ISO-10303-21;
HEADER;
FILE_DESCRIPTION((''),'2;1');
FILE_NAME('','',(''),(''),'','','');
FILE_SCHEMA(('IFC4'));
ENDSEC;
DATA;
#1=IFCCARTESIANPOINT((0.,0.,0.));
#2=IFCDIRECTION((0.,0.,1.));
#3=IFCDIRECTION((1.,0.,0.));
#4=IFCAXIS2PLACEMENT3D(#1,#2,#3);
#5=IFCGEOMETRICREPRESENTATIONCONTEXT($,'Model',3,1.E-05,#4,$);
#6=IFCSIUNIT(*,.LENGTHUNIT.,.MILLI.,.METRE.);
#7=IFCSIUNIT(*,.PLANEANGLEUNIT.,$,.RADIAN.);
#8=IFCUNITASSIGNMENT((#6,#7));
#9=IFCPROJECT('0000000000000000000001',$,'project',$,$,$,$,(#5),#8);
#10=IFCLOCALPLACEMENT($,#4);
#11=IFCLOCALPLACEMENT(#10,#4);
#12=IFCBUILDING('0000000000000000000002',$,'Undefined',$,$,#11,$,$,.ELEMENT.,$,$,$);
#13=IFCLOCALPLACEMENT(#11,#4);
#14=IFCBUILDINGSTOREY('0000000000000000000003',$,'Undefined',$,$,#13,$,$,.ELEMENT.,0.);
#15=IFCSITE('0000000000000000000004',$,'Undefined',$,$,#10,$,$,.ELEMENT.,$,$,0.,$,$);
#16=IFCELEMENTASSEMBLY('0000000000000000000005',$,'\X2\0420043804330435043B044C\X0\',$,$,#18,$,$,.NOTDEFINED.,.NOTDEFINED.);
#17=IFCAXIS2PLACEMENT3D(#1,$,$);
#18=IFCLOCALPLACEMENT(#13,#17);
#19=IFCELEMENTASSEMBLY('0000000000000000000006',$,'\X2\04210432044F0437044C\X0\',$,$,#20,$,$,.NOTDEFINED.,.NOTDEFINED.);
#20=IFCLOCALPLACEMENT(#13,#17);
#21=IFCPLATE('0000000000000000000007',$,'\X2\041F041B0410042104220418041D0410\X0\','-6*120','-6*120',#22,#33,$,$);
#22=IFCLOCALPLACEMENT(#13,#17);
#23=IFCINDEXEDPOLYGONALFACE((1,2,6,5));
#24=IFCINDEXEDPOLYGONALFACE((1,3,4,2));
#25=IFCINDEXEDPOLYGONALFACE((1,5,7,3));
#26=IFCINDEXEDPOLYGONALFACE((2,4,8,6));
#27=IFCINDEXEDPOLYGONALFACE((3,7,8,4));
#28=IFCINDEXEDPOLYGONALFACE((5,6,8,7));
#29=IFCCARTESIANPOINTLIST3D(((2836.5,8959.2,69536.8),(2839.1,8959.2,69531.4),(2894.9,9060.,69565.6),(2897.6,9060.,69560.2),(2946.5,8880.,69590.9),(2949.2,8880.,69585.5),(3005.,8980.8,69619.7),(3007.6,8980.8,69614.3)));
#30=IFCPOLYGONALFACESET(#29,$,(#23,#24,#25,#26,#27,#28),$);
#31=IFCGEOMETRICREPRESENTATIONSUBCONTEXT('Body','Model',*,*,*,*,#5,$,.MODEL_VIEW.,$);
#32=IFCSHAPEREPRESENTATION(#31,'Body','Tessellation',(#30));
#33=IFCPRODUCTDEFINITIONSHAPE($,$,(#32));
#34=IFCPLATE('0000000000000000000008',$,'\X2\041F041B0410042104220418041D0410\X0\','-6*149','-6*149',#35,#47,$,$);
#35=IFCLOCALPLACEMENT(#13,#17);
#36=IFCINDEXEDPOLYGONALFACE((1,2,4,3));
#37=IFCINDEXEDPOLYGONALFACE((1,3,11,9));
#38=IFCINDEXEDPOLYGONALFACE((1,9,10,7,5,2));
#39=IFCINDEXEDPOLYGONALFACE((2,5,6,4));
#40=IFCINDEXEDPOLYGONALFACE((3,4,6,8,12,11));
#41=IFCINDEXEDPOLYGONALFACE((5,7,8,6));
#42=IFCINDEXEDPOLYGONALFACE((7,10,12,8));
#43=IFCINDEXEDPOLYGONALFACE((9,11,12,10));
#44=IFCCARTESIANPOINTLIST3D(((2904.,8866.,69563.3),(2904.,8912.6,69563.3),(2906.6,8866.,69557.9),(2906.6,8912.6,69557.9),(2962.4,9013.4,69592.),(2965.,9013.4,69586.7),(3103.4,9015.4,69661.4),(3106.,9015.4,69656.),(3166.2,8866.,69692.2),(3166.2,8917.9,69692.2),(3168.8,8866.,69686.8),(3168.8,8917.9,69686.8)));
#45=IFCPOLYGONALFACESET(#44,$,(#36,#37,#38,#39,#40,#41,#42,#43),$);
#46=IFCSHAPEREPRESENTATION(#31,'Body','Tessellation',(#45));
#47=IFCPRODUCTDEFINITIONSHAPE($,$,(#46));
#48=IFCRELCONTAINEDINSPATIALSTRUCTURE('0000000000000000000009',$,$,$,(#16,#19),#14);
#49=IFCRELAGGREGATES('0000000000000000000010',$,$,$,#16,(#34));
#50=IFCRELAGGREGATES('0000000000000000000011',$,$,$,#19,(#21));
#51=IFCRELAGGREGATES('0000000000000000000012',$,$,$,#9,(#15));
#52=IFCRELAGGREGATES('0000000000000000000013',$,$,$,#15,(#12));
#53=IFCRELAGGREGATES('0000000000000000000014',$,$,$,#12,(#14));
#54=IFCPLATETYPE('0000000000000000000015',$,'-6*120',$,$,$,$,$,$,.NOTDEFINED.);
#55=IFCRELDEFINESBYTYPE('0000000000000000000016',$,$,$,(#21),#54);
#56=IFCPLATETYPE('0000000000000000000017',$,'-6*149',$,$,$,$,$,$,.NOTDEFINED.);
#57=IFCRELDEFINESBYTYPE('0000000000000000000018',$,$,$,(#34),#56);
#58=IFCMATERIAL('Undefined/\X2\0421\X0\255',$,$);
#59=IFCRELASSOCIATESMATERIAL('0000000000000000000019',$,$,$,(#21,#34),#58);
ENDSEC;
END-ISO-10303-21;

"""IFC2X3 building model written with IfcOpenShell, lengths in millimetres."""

from ifc_helpers import new_model, si_unit, frame, origin_with_axes, place, context, subcontext, project, spatial, polyline, outline, extrude, material, type_object, element, aggregate, save


model = new_model("IFC2X3")

# Units and contexts
model_context = context("Model", 3, precision=1e-05, world=origin_with_axes())
body_context = subcontext(model_context, "Body", "Model", "MODEL_VIEW")
ifc_project = project(units=[si_unit("LENGTHUNIT", "METRE", prefix="MILLI"), si_unit("PLANEANGLEUNIT", "RADIAN")], contexts=[model_context])

# Site, building, storey
site_placement = place(None, origin_with_axes())
site = spatial("IfcSite", under=ifc_project, at=site_placement, Name="Undefined", CompositionType="ELEMENT", RefElevation=0.0)
building_placement = place(site_placement, origin_with_axes())
building = spatial("IfcBuilding", under=site, at=building_placement, Name="Undefined", CompositionType="ELEMENT")
storey_placement = place(building_placement, origin_with_axes())
storey = spatial("IfcBuildingStorey", under=building, at=storey_placement, Name="Undefined", CompositionType="ELEMENT", Elevation=0.0)

# Element assembly
assembly_1_placement = place(storey_placement, origin_with_axes())
assembly_1 = element("IfcElementAssembly", 1, at=assembly_1_placement, inside=storey, Name="Ригель", AssemblyPlace="NOTDEFINED", PredefinedType="NOTDEFINED")
ifc_material_1 = material(Name="Undefined/С255")

# Element assembly
assembly_2_placement = place(storey_placement, origin_with_axes())
assembly_2 = element("IfcElementAssembly", 2, at=assembly_2_placement, inside=storey, Name="Связь", AssemblyPlace="NOTDEFINED", PredefinedType="NOTDEFINED")

# Plates
plate_type_1 = type_object("IfcPlateType", Name="-6*120", PredefinedType="NOTDEFINED")
plate_1_placement = place(assembly_2_placement, frame((2947.9, 8880.0, 69588.2), z_axis=(-0.441222, -0.000001, 0.897398), x_axis=(0.48707, 0.839889, 0.239478)))
plate_1 = element("IfcPlate", 3, at=plate_1_placement, type_object=plate_type_1, material=ifc_material_1, Name="ПЛАСТИНА", Description="-6*120", ObjectType="-6*120", context=body_context, shape_type="SweptSolid", body=[
    extrude(outline(polyline([(0.0, 0.0), (120.0, 0.0), (120.0, 146.0), (0.0, 146.0), (0.0, 0.0)])), frame((0.0, 0.0, -3.0), z_axis=(0.0, 0.0, 1.0), x_axis=(1.0, 0.0, 0.0)), (0.0, 0.0, 1.0), 6.0),
])
plate_type_2 = type_object("IfcPlateType", Name="-6*149", PredefinedType="NOTDEFINED")
plate_2_placement = place(assembly_1_placement, frame((2905.3, 8866.0, 69560.6), z_axis=(-0.441224, 0.0, 0.897397), x_axis=(0.897397, 0.000027, 0.441224)))
plate_2 = element("IfcPlate", 4, at=plate_2_placement, type_object=plate_type_2, material=ifc_material_1, Name="ПЛАСТИНА", Description="-6*149", ObjectType="-6*149", context=body_context, shape_type="SweptSolid", body=[
    extrude(outline(polyline([(0.0, 0.0), (292.2, 0.0), (292.2, 51.9), (222.2, 149.4), (65.1, 147.4), (0.0, 46.6), (0.0, 0.0)])), frame((0.0, 0.0, -3.0), z_axis=(0.0, 0.0, 1.0), x_axis=(1.0, 0.0, 0.0)), (0.0, 0.0, 1.0), 6.0),
])

aggregate(assembly_1, [plate_2])
aggregate(assembly_2, [plate_1])

save(model, "model.ifc")
